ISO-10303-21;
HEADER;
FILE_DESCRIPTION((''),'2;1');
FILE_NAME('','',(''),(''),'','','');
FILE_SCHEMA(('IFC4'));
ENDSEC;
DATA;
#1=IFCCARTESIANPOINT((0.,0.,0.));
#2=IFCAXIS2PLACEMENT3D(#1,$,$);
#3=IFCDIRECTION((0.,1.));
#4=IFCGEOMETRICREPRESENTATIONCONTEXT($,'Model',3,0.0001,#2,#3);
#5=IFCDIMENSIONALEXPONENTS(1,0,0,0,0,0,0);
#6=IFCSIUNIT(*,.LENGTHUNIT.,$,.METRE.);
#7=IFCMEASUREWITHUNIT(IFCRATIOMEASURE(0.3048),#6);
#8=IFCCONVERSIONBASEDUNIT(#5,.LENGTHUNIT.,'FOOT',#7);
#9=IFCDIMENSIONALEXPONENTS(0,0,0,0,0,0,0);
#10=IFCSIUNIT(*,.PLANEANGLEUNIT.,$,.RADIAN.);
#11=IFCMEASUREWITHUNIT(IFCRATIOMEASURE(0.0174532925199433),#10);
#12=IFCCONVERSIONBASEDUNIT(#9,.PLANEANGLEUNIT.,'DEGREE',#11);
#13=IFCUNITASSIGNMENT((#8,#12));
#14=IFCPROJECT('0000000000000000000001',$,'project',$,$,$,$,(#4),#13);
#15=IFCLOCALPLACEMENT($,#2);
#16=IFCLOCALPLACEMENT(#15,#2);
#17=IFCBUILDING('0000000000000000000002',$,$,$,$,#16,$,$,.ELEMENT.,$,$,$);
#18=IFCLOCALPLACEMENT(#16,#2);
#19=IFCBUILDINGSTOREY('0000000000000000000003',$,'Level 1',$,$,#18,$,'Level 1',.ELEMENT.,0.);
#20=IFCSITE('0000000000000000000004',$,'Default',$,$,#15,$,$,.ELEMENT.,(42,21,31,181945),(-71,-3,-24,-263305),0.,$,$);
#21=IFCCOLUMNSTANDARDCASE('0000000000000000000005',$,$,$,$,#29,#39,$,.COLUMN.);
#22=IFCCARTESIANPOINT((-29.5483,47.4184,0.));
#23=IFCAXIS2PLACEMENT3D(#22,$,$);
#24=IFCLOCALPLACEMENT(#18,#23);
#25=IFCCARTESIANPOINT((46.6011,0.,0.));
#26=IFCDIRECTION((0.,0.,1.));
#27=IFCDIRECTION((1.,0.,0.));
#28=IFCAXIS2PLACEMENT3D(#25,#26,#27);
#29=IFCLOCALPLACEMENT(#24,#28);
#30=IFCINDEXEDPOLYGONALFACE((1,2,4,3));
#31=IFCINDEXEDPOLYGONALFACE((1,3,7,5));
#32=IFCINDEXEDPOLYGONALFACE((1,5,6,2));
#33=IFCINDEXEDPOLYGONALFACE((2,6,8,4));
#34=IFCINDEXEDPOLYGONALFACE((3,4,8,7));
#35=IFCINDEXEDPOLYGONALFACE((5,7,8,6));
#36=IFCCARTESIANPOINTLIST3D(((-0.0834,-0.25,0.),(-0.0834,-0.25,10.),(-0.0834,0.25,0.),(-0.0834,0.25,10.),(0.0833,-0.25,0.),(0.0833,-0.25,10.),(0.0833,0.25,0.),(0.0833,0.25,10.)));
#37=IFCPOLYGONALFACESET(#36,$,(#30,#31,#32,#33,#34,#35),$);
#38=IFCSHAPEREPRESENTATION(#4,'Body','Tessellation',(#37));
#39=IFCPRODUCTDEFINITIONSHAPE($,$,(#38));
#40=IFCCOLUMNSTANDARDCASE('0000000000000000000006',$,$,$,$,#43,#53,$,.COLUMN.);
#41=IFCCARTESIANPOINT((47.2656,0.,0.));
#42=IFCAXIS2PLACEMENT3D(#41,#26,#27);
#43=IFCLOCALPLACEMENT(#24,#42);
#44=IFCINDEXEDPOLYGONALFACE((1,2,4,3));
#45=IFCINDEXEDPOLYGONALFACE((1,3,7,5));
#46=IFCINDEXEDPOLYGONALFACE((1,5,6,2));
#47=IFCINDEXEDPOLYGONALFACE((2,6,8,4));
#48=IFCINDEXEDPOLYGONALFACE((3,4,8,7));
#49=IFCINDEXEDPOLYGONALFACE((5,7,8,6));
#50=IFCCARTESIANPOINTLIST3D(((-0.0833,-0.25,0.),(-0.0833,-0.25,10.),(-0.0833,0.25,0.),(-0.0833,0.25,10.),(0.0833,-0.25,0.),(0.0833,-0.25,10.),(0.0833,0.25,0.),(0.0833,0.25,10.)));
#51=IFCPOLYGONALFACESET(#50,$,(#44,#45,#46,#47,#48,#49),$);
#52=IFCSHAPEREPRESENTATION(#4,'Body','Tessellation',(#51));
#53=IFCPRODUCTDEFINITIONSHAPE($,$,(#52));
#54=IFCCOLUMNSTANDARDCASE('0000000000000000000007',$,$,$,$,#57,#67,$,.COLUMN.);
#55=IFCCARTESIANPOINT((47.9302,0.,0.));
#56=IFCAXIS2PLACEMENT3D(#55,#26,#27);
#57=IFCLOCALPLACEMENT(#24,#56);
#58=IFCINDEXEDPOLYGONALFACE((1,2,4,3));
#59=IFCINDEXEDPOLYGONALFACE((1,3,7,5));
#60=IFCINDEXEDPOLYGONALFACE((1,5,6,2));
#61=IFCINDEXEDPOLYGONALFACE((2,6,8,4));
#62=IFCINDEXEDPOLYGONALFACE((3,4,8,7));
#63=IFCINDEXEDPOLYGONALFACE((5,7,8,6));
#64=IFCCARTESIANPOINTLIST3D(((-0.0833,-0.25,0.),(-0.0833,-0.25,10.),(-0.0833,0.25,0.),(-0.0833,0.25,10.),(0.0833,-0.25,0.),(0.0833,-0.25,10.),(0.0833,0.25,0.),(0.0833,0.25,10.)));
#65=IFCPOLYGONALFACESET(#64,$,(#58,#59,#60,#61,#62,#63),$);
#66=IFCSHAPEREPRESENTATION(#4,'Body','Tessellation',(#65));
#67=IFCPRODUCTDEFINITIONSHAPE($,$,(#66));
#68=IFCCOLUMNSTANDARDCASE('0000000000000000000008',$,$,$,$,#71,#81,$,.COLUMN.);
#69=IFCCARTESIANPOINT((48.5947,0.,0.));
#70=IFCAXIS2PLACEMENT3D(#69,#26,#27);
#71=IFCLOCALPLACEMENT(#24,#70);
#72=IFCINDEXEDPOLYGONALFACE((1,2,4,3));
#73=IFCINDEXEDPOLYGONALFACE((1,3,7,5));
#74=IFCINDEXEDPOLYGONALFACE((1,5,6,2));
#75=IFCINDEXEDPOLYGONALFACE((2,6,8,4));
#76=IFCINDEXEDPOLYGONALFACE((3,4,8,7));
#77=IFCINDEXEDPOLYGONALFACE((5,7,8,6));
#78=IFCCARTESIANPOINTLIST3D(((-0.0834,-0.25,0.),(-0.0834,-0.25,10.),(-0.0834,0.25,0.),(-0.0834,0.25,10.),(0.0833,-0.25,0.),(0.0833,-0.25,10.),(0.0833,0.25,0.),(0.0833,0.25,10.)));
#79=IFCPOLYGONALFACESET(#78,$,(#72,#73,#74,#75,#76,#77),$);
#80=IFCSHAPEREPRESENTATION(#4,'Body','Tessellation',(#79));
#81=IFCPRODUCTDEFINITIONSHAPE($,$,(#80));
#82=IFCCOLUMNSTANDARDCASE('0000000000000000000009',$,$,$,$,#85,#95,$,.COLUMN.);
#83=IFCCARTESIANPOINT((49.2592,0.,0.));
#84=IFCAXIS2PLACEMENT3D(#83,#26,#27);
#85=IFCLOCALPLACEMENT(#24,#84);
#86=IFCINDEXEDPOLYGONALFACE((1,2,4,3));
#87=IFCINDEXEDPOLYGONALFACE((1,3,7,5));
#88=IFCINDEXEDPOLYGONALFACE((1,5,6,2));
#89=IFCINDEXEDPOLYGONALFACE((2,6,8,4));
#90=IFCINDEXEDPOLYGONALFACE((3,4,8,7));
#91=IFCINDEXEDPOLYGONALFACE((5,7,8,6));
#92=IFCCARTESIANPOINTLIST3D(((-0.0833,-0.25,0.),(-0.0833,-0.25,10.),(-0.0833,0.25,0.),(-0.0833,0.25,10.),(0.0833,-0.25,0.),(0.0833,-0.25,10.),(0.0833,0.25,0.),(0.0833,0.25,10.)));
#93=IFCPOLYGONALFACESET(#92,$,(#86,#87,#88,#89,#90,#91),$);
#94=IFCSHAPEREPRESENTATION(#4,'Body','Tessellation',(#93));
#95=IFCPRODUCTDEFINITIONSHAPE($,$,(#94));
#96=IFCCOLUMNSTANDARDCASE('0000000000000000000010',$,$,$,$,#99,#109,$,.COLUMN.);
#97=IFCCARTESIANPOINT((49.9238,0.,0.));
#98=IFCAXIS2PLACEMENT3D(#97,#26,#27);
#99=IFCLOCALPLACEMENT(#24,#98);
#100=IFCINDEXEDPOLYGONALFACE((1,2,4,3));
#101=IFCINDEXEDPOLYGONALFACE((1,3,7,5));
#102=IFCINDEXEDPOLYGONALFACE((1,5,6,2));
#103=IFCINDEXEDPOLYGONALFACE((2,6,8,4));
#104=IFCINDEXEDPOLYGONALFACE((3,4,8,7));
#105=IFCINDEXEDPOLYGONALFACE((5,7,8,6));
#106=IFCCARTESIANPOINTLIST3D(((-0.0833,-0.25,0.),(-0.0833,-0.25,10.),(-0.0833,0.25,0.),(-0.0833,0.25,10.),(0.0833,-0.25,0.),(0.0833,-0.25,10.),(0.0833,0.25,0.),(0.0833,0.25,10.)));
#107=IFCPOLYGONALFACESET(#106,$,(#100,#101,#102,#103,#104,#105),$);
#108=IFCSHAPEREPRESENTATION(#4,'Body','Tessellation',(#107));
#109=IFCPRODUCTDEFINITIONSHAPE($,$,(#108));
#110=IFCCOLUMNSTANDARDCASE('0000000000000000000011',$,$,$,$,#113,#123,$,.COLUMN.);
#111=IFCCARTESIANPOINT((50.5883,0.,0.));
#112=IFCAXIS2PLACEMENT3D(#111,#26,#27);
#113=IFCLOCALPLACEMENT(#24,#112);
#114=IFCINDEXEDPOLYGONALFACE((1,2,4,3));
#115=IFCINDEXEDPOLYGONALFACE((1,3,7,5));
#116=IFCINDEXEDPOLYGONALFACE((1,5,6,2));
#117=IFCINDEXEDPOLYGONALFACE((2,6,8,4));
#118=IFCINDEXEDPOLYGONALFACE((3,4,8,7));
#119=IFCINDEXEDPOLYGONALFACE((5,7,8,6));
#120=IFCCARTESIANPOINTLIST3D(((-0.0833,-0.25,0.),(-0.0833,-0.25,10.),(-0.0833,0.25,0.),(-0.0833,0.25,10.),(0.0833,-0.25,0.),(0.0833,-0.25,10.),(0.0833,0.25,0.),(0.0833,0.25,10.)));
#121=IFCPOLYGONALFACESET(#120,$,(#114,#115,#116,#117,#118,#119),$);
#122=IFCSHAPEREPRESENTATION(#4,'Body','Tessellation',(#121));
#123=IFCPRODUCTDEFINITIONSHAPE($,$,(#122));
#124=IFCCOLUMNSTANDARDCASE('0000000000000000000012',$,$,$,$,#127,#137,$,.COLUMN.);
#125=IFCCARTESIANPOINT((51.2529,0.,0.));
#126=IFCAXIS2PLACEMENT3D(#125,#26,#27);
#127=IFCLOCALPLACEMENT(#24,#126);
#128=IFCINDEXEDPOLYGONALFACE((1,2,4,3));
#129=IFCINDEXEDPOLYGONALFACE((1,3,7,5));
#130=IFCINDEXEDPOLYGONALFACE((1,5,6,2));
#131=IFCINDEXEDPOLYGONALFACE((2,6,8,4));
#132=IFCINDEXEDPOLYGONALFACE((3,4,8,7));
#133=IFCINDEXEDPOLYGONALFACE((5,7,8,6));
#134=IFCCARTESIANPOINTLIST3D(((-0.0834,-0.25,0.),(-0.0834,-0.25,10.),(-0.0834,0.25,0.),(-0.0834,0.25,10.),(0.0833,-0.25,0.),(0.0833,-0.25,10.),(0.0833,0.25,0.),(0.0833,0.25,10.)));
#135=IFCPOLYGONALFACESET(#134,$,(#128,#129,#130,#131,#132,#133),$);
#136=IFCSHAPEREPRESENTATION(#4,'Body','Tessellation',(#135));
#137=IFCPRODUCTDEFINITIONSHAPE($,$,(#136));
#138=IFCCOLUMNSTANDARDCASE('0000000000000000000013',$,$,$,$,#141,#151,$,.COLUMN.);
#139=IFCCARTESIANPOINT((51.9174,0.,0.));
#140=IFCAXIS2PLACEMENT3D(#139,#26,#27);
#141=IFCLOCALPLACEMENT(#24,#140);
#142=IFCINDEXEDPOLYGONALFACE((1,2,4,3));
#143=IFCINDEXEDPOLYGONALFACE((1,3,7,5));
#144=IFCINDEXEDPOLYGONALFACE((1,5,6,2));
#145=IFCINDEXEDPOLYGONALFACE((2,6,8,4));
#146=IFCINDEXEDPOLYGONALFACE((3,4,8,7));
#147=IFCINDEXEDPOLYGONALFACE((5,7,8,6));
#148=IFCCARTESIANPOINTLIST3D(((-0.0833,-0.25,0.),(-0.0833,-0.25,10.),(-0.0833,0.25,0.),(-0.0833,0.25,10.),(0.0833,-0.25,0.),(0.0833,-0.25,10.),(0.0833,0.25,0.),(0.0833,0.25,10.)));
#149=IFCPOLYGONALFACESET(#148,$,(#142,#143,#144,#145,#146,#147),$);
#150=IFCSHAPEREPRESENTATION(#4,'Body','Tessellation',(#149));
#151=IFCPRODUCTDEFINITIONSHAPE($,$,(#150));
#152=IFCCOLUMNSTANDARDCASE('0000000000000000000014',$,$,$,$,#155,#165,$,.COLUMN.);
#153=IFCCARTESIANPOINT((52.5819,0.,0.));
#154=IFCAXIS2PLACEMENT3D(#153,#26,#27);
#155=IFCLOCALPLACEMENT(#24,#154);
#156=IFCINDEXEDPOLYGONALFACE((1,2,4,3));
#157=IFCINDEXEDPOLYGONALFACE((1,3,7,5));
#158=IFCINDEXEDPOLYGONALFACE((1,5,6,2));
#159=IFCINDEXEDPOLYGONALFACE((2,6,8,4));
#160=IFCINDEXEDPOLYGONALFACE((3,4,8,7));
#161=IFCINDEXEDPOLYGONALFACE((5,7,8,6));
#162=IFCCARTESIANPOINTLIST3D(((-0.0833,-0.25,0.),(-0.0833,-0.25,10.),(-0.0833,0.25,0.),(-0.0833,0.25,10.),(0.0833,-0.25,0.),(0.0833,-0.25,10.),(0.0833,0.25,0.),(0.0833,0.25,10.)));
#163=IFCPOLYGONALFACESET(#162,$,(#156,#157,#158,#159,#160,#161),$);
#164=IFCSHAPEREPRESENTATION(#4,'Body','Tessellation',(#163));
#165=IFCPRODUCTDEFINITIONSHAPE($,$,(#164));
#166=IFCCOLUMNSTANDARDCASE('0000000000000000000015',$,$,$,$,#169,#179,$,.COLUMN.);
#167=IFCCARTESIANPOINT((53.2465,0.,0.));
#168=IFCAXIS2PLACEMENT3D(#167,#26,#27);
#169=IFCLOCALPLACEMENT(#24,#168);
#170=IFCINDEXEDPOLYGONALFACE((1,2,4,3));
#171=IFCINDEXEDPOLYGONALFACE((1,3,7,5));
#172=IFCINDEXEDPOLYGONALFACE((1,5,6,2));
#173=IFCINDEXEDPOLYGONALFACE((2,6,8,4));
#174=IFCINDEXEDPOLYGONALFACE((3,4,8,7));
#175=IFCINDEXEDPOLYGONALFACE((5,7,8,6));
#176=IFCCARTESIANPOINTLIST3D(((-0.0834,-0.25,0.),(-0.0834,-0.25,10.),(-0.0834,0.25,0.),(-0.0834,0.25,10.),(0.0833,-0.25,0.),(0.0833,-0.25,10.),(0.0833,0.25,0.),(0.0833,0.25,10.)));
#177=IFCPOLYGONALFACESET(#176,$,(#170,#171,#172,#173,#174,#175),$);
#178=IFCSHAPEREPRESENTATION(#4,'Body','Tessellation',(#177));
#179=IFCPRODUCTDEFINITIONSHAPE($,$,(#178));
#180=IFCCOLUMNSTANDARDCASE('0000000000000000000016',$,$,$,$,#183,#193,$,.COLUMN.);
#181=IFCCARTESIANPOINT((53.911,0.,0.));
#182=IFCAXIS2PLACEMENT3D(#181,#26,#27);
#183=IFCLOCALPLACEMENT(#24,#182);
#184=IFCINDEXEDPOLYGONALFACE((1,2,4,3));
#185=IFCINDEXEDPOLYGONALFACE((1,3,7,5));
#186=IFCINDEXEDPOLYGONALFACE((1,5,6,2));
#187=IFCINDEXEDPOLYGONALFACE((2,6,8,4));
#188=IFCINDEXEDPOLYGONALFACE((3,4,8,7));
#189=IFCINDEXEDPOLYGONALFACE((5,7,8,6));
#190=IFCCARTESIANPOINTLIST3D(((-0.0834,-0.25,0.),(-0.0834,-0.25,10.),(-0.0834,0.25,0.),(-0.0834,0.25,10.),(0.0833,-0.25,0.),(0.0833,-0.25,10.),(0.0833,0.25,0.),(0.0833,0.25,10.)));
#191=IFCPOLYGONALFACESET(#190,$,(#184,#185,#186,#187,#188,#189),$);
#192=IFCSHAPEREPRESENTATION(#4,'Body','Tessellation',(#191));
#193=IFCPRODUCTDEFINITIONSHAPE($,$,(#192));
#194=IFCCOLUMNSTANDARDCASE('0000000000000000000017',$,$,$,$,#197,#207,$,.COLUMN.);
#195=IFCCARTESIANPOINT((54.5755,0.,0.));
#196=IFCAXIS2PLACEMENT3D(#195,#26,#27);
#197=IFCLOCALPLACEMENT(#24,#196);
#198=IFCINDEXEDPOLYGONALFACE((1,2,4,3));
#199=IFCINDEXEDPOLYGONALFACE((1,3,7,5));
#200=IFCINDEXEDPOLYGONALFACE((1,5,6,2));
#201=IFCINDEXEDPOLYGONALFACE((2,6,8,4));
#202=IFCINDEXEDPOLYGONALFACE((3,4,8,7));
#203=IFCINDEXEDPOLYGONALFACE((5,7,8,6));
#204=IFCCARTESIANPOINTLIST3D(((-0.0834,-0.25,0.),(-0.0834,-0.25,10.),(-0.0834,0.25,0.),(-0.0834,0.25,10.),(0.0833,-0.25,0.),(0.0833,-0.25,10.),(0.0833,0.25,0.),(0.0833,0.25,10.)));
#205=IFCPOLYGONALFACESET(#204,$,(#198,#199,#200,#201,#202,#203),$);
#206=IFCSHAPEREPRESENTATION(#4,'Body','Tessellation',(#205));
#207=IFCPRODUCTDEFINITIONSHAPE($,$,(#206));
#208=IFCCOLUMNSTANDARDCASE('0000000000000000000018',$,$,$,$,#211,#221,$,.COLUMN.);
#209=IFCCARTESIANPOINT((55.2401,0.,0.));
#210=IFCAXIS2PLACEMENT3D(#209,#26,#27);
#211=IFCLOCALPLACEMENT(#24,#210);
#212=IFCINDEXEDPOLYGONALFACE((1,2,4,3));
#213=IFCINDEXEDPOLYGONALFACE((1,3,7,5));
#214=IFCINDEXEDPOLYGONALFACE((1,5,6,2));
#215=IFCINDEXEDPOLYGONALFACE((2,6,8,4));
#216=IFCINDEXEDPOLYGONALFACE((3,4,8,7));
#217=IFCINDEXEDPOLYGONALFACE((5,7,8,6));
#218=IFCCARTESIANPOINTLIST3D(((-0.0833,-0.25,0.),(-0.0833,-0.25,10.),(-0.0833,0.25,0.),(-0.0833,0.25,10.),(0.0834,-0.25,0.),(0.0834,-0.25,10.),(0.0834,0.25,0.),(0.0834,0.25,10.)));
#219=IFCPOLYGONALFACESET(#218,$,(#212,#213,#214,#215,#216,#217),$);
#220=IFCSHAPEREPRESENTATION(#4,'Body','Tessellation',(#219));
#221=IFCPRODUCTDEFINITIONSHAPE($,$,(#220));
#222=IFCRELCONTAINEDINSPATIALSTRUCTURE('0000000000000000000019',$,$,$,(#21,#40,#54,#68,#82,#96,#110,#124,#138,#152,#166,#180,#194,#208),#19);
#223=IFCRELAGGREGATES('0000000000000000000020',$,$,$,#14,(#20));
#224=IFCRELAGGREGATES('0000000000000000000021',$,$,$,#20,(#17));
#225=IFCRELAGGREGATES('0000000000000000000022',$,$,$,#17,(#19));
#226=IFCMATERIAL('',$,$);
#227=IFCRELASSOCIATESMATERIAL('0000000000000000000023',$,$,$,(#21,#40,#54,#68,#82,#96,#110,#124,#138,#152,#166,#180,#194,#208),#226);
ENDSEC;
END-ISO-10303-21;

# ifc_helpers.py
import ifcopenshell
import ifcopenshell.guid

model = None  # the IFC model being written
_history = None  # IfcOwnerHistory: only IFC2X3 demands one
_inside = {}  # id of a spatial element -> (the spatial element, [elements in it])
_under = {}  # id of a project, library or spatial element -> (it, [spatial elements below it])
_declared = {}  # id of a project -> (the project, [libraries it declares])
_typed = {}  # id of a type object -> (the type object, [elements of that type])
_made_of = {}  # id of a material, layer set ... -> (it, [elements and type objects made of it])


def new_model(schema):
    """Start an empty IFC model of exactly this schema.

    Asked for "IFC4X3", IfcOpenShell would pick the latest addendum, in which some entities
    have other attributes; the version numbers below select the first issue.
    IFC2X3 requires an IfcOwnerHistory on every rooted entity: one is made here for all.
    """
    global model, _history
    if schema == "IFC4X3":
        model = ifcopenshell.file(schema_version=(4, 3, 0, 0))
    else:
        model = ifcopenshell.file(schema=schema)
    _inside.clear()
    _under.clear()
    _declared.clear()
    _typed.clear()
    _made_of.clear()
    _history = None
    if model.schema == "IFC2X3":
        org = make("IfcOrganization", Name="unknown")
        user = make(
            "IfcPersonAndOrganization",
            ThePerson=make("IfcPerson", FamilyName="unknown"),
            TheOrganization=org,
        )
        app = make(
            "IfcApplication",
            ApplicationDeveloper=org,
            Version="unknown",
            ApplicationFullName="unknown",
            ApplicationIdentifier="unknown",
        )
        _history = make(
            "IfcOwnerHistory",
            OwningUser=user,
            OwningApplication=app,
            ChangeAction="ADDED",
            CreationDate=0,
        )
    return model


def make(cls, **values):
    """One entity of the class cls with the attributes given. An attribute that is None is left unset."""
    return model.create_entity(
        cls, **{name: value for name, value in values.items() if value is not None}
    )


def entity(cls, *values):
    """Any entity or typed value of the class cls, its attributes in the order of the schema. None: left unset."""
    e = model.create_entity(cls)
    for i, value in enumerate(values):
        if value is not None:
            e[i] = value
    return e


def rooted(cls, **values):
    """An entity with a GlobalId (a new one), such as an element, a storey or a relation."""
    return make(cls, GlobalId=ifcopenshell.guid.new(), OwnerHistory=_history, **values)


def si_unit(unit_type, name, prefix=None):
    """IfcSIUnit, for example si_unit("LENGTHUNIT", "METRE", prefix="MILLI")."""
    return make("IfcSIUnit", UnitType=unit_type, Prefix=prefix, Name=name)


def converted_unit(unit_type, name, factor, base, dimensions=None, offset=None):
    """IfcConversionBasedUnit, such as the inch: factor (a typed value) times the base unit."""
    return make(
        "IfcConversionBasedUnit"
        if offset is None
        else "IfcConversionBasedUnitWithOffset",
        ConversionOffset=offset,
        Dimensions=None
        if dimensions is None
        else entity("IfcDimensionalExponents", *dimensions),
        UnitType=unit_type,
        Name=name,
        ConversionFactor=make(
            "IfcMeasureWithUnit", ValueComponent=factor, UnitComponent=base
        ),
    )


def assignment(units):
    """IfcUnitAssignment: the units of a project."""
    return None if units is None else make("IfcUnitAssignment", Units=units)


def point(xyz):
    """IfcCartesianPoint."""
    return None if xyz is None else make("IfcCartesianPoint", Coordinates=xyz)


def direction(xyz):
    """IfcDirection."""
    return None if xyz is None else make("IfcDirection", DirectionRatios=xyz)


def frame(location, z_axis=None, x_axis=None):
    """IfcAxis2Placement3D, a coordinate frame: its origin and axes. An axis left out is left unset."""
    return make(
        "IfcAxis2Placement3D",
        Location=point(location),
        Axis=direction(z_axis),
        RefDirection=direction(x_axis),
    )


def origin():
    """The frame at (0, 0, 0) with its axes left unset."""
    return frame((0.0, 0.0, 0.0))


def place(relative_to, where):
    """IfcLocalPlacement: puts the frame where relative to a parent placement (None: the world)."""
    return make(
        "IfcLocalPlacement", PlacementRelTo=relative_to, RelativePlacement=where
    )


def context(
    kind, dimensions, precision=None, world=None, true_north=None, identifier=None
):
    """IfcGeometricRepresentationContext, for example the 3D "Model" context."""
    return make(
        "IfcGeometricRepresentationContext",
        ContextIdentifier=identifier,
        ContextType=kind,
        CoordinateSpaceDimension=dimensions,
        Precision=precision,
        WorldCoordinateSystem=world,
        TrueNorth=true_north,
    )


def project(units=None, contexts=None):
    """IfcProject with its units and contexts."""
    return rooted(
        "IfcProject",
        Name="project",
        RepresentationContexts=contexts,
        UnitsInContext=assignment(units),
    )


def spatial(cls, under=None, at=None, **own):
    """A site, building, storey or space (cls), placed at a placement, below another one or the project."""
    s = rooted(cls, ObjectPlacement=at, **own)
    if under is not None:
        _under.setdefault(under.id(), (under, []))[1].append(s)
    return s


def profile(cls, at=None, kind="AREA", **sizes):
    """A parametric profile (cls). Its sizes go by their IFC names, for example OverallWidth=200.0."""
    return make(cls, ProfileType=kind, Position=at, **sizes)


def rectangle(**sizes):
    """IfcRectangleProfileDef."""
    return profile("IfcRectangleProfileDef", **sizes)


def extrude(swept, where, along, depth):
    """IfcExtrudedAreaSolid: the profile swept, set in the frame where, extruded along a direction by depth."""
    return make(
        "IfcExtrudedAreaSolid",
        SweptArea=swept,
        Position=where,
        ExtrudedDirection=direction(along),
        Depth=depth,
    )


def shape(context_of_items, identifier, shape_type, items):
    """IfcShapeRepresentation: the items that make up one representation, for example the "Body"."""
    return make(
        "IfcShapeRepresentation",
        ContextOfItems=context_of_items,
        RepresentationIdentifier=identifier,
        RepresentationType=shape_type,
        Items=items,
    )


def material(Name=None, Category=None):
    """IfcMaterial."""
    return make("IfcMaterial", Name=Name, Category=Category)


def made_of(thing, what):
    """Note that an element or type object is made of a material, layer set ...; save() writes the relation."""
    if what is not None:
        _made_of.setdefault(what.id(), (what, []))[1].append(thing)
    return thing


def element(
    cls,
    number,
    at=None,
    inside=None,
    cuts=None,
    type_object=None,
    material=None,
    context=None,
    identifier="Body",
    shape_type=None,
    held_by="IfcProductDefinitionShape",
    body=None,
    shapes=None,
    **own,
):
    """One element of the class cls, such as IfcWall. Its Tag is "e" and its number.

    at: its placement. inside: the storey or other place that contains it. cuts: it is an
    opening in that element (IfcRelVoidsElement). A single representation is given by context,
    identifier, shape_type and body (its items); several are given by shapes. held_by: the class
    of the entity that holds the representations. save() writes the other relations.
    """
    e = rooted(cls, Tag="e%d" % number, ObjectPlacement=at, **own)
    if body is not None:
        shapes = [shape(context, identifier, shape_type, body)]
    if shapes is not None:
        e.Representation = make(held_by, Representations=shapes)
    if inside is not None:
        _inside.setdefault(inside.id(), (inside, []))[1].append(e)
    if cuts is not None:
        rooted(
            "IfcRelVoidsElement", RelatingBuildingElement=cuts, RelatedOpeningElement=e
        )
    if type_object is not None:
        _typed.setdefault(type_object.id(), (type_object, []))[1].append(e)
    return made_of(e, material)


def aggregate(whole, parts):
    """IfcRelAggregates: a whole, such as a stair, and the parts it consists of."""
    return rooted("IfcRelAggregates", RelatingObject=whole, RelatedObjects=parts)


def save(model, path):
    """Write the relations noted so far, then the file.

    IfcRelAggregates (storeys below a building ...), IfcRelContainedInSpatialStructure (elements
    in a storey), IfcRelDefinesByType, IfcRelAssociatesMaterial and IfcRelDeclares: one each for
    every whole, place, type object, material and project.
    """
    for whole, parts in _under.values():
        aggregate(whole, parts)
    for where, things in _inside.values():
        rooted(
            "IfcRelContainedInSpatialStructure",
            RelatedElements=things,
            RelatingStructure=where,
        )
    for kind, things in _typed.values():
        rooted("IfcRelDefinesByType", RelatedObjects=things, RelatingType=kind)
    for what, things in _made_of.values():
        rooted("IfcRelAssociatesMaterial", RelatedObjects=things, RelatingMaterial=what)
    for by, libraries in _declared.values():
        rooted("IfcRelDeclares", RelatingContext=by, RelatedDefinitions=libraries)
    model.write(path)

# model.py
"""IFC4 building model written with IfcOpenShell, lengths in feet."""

from ifc_helpers import new_model, entity, si_unit, converted_unit, direction, frame, origin, place, context, project, spatial, rectangle, extrude, material, element, save


model = new_model("IFC4")

# Units and contexts
model_context = context("Model", 3, precision=0.0001, world=origin(), true_north=direction((0.0, 1.0)))
ifc_project = project(units=[converted_unit("LENGTHUNIT", "FOOT", entity("IfcRatioMeasure", 0.3048), si_unit("LENGTHUNIT", "METRE"), dimensions=[1, 0, 0, 0, 0, 0, 0]), converted_unit("PLANEANGLEUNIT", "DEGREE", entity("IfcRatioMeasure", 0.0174532925199433), si_unit("PLANEANGLEUNIT", "RADIAN"), dimensions=[0, 0, 0, 0, 0, 0, 0])], contexts=[model_context])

# Site, building, storey
site_placement = place(None, origin())
site = spatial("IfcSite", under=ifc_project, at=site_placement, Name="Default", CompositionType="ELEMENT", RefLatitude=(42, 21, 31, 181945), RefLongitude=(-71, -3, -24, -263305), RefElevation=0.0)
building_placement = place(site_placement, origin())
building = spatial("IfcBuilding", under=site, at=building_placement, CompositionType="ELEMENT")
storey_placement = place(building_placement, origin())
storey = spatial("IfcBuildingStorey", under=building, at=storey_placement, Name="Level 1", LongName="Level 1", CompositionType="ELEMENT", Elevation=0.0)

# Columns
ifc_material_1 = material(Name="")
placement = place(storey_placement, frame((-29.5483, 47.4184, 0.0)))
for number, where, z_axis, x_axis in (
    (1, (46.6011, 0.0, 0.0), (0.0, 0.0, 1.0), (1.0, 0.0, 0.0)),
    (2, (47.2656, 0.0, 0.0), (0.0, 0.0, 1.0), (1.0, 0.0, 0.0)),
    (3, (47.9302, 0.0, 0.0), (0.0, 0.0, 1.0), (1.0, 0.0, 0.0)),
    (4, (48.5947, 0.0, 0.0), (0.0, 0.0, 1.0), (1.0, 0.0, 0.0)),
    (5, (49.2592, 0.0, 0.0), (0.0, 0.0, 1.0), (1.0, 0.0, 0.0)),
    (6, (49.9238, 0.0, 0.0), (0.0, 0.0, 1.0), (1.0, 0.0, 0.0)),
    (7, (50.5883, 0.0, 0.0), (0.0, 0.0, 1.0), (1.0, 0.0, 0.0)),
    (8, (51.2529, 0.0, 0.0), (0.0, 0.0, 1.0), (1.0, 0.0, 0.0)),
    (9, (51.9174, 0.0, 0.0), (0.0, 0.0, 1.0), (1.0, 0.0, 0.0)),
    (10, (52.5819, 0.0, 0.0), (0.0, 0.0, 1.0), (1.0, 0.0, 0.0)),
    (11, (53.2465, 0.0, 0.0), (0.0, 0.0, 1.0), (1.0, 0.0, 0.0)),
    (12, (53.911, 0.0, 0.0), (0.0, 0.0, 1.0), (1.0, 0.0, 0.0)),
    (13, (54.5755, 0.0, 0.0), (0.0, 0.0, 1.0), (1.0, 0.0, 0.0)),
    (14, (55.2401, 0.0, 0.0), (0.0, 0.0, 1.0), (1.0, 0.0, 0.0)),
):
    element("IfcColumnStandardCase", number, at=place(placement, frame(where, z_axis=z_axis, x_axis=x_axis)), inside=storey, material=ifc_material_1, PredefinedType="COLUMN", context=model_context, shape_type="SweptSolid", body=[
        extrude(rectangle(XDim=0.1667, YDim=0.5), origin(), (0.0, 0.0, 1.0), 10.0),
    ])

save(model, "model.ifc")
